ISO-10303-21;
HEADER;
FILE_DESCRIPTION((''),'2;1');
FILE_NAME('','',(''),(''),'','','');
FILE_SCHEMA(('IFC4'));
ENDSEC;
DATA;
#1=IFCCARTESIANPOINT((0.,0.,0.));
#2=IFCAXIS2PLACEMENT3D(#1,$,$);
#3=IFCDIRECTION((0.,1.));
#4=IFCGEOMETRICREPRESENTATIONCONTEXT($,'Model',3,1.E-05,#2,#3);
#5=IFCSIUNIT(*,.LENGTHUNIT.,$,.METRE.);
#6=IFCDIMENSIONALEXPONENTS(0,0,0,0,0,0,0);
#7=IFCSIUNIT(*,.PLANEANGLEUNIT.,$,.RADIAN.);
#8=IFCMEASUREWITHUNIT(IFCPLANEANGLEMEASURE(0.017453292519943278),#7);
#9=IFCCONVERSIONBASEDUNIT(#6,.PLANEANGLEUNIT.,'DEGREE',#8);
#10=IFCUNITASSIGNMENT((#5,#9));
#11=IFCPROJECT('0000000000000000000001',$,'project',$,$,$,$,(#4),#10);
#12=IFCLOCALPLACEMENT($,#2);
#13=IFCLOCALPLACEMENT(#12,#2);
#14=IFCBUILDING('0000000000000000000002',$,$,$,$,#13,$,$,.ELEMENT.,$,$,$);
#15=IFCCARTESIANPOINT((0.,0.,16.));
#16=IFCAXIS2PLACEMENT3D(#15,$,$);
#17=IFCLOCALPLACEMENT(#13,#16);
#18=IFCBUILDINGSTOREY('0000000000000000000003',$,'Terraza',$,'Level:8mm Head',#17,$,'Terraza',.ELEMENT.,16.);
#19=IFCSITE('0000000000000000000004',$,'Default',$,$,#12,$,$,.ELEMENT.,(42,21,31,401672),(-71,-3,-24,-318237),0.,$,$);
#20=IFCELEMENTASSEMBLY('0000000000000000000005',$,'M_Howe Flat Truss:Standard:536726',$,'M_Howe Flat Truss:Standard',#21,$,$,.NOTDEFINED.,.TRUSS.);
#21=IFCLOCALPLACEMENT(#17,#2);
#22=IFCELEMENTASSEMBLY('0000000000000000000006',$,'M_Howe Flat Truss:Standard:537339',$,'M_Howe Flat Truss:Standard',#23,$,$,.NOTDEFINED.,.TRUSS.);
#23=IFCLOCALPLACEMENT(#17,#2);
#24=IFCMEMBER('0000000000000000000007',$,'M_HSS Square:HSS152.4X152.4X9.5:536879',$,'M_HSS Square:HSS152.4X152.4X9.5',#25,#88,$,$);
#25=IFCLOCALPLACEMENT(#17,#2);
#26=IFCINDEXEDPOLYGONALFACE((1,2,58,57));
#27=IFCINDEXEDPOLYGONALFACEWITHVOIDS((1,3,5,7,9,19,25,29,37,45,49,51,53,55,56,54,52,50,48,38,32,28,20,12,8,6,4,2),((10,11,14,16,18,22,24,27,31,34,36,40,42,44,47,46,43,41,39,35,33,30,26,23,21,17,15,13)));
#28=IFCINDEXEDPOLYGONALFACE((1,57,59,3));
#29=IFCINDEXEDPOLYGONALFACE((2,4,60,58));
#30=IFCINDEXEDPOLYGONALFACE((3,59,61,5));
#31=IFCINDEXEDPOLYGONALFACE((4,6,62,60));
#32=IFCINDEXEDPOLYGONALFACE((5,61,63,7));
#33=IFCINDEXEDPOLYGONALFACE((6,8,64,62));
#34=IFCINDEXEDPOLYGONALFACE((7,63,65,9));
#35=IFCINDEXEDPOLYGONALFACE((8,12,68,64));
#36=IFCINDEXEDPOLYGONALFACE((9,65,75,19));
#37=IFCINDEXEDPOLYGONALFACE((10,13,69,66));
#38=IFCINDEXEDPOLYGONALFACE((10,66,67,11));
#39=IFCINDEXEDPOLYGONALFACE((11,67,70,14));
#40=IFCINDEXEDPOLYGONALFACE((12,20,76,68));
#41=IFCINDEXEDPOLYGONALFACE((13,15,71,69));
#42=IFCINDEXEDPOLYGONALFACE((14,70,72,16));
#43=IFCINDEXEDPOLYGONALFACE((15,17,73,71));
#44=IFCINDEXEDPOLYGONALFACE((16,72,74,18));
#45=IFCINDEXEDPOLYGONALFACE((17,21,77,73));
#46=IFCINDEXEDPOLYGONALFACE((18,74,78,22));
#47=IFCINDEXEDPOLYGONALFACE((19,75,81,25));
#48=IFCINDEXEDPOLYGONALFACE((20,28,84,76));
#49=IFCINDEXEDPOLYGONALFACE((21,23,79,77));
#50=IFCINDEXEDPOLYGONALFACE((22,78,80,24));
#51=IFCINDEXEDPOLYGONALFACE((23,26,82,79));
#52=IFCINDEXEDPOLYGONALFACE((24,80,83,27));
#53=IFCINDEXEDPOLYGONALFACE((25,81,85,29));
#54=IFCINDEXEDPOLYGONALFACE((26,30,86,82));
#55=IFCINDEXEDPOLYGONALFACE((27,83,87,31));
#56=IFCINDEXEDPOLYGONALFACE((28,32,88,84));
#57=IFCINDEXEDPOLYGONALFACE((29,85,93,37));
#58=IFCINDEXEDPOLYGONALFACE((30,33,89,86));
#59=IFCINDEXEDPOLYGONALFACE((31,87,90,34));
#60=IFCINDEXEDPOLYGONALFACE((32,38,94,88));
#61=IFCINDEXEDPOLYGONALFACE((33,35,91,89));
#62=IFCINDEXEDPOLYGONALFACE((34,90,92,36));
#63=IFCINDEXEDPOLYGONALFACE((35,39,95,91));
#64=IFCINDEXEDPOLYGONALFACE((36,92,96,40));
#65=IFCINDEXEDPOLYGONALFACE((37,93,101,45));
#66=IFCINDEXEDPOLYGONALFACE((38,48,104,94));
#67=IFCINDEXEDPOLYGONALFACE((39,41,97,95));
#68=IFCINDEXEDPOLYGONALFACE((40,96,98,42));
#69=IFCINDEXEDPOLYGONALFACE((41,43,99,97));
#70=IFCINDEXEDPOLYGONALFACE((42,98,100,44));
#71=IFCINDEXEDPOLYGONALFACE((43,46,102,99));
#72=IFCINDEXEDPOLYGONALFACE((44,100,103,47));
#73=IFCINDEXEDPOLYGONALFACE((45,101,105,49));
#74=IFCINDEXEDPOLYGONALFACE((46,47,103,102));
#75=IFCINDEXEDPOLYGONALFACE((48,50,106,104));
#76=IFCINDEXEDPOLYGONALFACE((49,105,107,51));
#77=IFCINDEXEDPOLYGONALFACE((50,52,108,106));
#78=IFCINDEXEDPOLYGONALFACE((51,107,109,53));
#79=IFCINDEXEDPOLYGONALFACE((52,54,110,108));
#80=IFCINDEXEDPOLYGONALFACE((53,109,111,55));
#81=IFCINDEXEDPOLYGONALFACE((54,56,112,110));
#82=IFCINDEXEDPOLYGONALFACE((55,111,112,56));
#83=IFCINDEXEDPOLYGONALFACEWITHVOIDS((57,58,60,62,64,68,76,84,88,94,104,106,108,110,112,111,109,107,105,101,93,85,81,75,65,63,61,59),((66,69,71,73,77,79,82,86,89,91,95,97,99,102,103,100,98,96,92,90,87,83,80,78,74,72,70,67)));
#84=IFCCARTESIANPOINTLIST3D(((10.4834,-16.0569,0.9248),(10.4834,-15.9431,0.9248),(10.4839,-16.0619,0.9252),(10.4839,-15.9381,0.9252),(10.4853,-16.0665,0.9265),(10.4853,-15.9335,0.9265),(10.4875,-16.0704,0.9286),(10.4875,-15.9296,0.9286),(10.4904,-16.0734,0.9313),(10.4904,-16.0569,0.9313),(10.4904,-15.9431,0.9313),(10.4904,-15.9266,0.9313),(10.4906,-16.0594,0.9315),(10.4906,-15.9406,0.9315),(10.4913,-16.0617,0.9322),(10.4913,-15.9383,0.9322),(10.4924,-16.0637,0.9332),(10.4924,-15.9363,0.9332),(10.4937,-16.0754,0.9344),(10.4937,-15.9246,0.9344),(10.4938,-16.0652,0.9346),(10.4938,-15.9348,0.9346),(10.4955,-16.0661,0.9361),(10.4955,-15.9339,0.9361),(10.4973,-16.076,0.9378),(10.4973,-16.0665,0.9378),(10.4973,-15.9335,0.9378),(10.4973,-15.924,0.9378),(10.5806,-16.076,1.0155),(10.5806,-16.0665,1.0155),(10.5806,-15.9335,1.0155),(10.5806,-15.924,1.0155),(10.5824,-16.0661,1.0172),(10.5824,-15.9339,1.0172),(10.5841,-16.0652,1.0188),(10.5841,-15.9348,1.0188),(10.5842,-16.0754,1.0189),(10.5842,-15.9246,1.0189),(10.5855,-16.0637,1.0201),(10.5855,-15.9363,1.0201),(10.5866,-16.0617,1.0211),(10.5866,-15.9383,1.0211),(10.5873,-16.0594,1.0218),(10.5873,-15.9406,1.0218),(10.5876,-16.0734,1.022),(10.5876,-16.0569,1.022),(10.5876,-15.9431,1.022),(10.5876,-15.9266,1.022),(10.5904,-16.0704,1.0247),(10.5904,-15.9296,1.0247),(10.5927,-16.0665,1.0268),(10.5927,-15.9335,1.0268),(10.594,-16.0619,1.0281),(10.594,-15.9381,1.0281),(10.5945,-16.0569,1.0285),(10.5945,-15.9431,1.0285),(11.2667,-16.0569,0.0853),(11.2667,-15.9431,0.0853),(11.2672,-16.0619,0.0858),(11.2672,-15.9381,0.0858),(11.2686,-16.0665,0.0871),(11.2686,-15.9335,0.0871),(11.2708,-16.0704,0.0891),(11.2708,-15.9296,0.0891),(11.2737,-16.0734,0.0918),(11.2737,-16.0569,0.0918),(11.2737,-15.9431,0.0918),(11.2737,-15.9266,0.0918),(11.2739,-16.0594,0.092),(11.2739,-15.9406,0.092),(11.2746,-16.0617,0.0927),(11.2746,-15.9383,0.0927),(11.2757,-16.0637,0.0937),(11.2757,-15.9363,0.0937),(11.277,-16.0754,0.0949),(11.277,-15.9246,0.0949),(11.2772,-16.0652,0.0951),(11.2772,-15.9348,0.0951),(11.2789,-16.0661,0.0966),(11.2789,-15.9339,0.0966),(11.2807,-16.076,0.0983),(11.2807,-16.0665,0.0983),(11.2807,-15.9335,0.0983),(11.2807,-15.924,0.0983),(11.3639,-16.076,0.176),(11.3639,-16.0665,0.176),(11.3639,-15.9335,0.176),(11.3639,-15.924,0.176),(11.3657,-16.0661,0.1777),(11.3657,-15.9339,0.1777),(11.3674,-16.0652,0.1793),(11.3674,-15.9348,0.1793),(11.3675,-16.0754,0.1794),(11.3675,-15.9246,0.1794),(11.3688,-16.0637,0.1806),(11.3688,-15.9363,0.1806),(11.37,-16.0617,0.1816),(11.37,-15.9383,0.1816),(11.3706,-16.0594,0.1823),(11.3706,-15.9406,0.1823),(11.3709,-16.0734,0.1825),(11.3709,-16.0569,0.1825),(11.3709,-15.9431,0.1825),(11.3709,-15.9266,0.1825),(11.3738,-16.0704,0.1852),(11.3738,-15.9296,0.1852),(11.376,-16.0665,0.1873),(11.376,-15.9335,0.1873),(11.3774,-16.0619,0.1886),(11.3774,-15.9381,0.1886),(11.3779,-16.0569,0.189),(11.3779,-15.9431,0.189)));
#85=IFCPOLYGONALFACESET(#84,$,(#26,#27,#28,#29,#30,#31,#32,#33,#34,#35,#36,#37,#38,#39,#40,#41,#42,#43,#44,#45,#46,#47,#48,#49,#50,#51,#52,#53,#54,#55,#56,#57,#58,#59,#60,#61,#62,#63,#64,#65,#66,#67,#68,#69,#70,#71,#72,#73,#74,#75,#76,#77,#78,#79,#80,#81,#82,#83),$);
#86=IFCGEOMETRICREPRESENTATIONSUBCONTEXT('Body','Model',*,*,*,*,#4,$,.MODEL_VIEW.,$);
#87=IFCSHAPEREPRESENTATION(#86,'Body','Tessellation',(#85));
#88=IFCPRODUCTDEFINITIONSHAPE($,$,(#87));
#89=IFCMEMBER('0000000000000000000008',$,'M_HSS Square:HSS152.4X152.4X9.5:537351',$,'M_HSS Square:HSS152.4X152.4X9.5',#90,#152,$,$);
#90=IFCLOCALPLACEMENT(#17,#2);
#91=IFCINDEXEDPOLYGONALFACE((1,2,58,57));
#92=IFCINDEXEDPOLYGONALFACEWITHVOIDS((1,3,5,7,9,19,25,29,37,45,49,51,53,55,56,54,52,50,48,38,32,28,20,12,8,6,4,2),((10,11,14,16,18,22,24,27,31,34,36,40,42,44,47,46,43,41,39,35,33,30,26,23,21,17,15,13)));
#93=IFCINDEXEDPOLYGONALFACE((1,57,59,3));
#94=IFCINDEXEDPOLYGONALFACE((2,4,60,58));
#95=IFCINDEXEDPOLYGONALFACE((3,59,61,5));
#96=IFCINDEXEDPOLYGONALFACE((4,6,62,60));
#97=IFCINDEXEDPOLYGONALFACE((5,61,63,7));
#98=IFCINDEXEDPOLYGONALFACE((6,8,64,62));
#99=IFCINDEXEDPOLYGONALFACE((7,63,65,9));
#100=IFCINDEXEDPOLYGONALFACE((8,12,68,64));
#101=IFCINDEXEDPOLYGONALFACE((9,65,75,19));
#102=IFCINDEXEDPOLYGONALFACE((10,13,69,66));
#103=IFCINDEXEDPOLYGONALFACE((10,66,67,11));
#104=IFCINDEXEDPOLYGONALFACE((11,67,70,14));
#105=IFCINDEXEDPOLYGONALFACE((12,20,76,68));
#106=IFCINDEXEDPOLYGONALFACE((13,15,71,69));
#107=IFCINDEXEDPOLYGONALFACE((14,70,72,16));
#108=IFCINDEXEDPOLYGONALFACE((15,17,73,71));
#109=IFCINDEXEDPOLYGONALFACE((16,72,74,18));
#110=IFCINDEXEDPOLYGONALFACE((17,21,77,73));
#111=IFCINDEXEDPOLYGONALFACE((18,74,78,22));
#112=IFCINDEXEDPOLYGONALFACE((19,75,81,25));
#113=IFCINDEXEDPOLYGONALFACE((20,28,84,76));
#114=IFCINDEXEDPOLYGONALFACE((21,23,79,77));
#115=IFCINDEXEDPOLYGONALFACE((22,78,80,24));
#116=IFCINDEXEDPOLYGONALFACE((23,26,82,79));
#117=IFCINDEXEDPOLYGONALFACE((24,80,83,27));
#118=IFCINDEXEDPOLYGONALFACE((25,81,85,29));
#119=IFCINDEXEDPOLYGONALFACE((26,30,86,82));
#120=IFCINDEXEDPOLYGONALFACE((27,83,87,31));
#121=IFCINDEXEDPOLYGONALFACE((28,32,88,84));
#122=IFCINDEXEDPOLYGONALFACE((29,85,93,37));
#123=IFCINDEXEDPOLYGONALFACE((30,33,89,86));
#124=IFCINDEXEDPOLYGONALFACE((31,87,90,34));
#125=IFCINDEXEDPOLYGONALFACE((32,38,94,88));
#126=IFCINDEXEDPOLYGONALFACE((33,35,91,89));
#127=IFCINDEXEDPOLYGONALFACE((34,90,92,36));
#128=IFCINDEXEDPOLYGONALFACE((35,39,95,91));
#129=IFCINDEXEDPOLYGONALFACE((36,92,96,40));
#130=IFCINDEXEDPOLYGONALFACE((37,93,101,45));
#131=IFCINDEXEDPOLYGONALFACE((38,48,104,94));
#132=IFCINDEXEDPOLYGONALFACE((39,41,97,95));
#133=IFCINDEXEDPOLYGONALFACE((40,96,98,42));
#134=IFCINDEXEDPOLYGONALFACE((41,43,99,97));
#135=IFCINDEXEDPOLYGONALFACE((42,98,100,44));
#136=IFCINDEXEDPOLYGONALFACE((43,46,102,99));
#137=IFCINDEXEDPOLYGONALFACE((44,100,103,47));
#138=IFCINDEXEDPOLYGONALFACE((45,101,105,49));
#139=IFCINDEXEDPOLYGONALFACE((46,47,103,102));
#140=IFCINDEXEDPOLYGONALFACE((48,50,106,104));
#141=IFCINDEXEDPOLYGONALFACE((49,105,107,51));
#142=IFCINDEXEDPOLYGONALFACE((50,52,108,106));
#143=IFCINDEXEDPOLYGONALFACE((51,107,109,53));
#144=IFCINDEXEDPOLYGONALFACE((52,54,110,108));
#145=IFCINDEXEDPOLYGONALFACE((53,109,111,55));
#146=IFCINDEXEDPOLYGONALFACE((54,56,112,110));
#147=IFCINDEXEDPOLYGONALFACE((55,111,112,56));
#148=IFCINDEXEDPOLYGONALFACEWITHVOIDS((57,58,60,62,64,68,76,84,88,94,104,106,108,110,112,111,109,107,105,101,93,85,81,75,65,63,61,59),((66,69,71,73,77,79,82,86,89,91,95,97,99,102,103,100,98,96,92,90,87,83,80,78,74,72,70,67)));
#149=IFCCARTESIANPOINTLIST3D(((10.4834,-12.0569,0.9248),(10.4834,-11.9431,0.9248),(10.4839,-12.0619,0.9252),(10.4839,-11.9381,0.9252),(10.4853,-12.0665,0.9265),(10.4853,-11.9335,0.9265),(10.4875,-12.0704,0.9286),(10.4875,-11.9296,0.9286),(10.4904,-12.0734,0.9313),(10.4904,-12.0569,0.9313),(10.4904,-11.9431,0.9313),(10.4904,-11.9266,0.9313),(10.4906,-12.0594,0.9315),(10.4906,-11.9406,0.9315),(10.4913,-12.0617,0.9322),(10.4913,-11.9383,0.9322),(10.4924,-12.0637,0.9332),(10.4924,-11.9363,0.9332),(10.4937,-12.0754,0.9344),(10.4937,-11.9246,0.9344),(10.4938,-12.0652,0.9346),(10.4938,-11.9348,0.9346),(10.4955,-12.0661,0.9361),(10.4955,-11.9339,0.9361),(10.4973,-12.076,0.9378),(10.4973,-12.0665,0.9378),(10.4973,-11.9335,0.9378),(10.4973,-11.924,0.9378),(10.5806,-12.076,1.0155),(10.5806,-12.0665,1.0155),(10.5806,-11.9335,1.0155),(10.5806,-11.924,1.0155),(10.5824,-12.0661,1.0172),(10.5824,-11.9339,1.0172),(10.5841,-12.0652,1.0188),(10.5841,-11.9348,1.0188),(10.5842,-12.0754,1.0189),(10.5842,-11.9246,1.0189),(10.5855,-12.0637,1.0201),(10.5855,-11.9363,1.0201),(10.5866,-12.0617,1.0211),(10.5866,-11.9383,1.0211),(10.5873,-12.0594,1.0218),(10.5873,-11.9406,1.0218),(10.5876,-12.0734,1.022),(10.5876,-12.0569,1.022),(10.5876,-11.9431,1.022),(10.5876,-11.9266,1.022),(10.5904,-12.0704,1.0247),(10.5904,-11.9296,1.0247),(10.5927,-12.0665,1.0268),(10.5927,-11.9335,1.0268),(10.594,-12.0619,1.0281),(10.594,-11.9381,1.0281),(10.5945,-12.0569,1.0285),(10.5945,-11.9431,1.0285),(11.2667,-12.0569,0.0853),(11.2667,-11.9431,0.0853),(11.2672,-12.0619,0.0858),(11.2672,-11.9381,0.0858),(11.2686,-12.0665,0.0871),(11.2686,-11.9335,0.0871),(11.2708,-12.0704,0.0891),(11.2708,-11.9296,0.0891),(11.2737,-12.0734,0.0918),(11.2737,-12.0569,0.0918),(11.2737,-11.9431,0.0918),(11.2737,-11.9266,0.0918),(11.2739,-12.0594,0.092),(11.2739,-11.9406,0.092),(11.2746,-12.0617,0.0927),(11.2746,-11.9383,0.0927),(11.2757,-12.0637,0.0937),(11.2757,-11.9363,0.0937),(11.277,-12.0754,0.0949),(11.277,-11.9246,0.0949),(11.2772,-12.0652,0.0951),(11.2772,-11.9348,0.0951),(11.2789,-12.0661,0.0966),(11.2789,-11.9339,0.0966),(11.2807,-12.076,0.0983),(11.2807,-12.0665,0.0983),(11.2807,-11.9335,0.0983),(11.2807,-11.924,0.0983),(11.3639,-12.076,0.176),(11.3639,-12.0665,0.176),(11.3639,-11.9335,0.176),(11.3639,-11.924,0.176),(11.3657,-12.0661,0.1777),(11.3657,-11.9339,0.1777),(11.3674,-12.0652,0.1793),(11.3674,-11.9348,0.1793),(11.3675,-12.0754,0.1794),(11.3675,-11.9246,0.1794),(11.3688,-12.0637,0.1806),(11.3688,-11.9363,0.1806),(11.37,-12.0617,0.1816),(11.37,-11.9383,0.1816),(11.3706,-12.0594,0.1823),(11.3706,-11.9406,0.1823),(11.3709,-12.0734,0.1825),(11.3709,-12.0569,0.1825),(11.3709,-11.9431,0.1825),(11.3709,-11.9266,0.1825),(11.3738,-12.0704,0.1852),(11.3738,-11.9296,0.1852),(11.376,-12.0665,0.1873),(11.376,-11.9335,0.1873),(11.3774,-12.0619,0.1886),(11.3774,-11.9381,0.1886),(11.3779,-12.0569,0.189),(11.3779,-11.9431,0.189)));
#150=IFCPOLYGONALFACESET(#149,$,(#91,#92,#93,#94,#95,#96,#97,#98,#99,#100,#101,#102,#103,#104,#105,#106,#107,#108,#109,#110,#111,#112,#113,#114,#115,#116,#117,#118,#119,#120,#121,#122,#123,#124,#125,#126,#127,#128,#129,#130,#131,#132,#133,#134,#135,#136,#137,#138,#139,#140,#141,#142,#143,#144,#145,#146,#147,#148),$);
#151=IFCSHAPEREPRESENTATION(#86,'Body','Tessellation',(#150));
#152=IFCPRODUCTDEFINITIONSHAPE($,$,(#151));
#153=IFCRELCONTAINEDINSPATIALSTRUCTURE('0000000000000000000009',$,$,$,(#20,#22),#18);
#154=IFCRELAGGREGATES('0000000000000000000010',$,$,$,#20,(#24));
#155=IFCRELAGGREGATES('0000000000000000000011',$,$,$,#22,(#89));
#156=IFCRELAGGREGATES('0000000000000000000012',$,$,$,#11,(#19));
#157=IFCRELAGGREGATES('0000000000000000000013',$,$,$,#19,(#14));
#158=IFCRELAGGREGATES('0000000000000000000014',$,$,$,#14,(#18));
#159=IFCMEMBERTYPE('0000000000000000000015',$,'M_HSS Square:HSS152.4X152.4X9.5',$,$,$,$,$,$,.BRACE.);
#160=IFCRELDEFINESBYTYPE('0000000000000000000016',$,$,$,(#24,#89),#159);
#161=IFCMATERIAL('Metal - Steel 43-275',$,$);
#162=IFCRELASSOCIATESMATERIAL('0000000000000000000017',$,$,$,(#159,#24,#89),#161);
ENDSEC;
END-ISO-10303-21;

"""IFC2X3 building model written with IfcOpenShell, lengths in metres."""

from ifc_helpers import new_model, entity, si_unit, converted_unit, direction, frame, frame_2d, origin, place, context, subcontext, project, spatial, polyline, circle_curve, parameter, trimmed, segment, composite_curve, outline, extrude, source, transform, mapped, material, type_object, type_shapes, element, aggregate, save


model = new_model("IFC2X3")

# Units and contexts
model_context = context("Model", 3, precision=1e-05, world=origin(), true_north=direction((0.0, 1.0)))
body_context = subcontext(model_context, "Body", "Model", "MODEL_VIEW")
ifc_project = project(units=[si_unit("LENGTHUNIT", "METRE"), converted_unit("PLANEANGLEUNIT", "DEGREE", entity("IfcPlaneAngleMeasure", 0.017453292519943278), si_unit("PLANEANGLEUNIT", "RADIAN"), dimensions=[0, 0, 0, 0, 0, 0, 0])], contexts=[model_context])

# Site, building, storey
site_placement = place(None, origin())
site = spatial("IfcSite", under=ifc_project, at=site_placement, Name="Default", CompositionType="ELEMENT", RefLatitude=(42, 21, 31, 401672), RefLongitude=(-71, -3, -24, -318237), RefElevation=0.0)
building_placement = place(site_placement, origin())
building = spatial("IfcBuilding", under=site, at=building_placement, CompositionType="ELEMENT")
storey_placement = place(building_placement, frame((0.0, 0.0, 16.0)))
storey = spatial("IfcBuildingStorey", under=building, at=storey_placement, Name="Terraza", ObjectType="Level:8mm Head", LongName="Terraza", CompositionType="ELEMENT", Elevation=16.0)

# Element assemblies
assembly_1_placement = place(storey_placement, origin())
assembly_1 = element("IfcElementAssembly", 1, at=assembly_1_placement, inside=storey, Name="M_Howe Flat Truss:Standard:536726", ObjectType="M_Howe Flat Truss:Standard", AssemblyPlace="NOTDEFINED", PredefinedType="TRUSS")
ifc_material = material(Name="Metal - Steel 43-275")
assembly_2_placement = place(storey_placement, origin())
assembly_2 = element("IfcElementAssembly", 2, at=assembly_2_placement, inside=storey, Name="M_Howe Flat Truss:Standard:537339", ObjectType="M_Howe Flat Truss:Standard", AssemblyPlace="NOTDEFINED", PredefinedType="TRUSS")

# Members
member_type_1 = type_object("IfcMemberType", Name="M_HSS Square:HSS152.4X152.4X9.5", PredefinedType="BRACE", material=ifc_material)
shared_shape_1 = source(origin(), body_context, "Body", "SweptSolid", [
    extrude(outline(composite_curve([segment(polyline([(-0.0569, -0.076), (0.0569, -0.076)]), True, "CONTINUOUS"), segment(trimmed(circle_curve(frame_2d((0.0569, -0.0569), x_axis=(0.0, 1.0)), 0.0191), [parameter(180.0)], [parameter(270.0)], True, "PARAMETER"), True, "CONTINUOUS"), segment(polyline([(0.076, -0.0569), (0.076, 0.0569)]), True, "CONTINUOUS"), segment(trimmed(circle_curve(frame_2d((0.0569, 0.0569), x_axis=(0.0, 1.0)), 0.0191), [parameter(270.0)], [parameter(0.0)], True, "PARAMETER"), True, "CONTINUOUS"), segment(polyline([(0.0569, 0.076), (-0.0569, 0.076)]), True, "CONTINUOUS"), segment(trimmed(circle_curve(frame_2d((-0.0569, 0.0569), x_axis=(0.0, 1.0)), 0.0191), [parameter(0.0)], [parameter(90.0)], True, "PARAMETER"), True, "CONTINUOUS"), segment(polyline([(-0.076, 0.0569), (-0.076, -0.0569)]), True, "CONTINUOUS"), segment(trimmed(circle_curve(frame_2d((-0.0569, -0.0569), x_axis=(0.0, 1.0)), 0.0191), [parameter(90.0)], [parameter(180.0)], True, "PARAMETER"), True, "CONTINUOUS")], self_intersect=False), holes=[composite_curve([segment(trimmed(circle_curve(frame_2d((-0.0569, 0.0569), x_axis=(0.0, 1.0)), 0.0095), [parameter(360.0)], [parameter(90.0)], True, "PARAMETER"), False, "CONTINUOUS"), segment(polyline([(-0.0569, 0.0665), (0.0569, 0.0665)]), True, "CONTINUOUS"), segment(trimmed(circle_curve(frame_2d((0.0569, 0.0569), x_axis=(0.0, 1.0)), 0.0095), [parameter(270.0)], [parameter(360.0)], True, "PARAMETER"), False, "CONTINUOUS"), segment(polyline([(0.0665, 0.0569), (0.0665, -0.0569)]), True, "CONTINUOUS"), segment(trimmed(circle_curve(frame_2d((0.0569, -0.0569), x_axis=(0.0, 1.0)), 0.0095), [parameter(180.0)], [parameter(270.0)], True, "PARAMETER"), False, "CONTINUOUS"), segment(polyline([(0.0569, -0.0665), (-0.0569, -0.0665)]), True, "CONTINUOUS"), segment(trimmed(circle_curve(frame_2d((-0.0569, -0.0569), x_axis=(0.0, 1.0)), 0.0095), [parameter(90.0)], [parameter(180.0)], True, "PARAMETER"), False, "CONTINUOUS"), segment(polyline([(-0.0665, -0.0569), (-0.0665, 0.0569)]), True, "CONTINUOUS")], self_intersect=False)]), frame((-0.5665, 0.0, 0.0), z_axis=(1.0, 0.0, 0.0), x_axis=(0.0, 0.0, -1.0)), (0.0, 0.0, 1.0), 1.1482),
])
type_shapes(member_type_1, [shared_shape_1])
member_1_placement = place(assembly_1_placement, frame((10.9254, -16.0, 0.5625), z_axis=(-0.731142, 0.0, -0.682225), x_axis=(0.682225, 0.0, -0.731142)))
member_1 = element("IfcMember", 3, at=member_1_placement, type_object=member_type_1, material=ifc_material, Name="M_HSS Square:HSS152.4X152.4X9.5:536879", ObjectType="M_HSS Square:HSS152.4X152.4X9.5", context=body_context, shape_type="MappedRepresentation", body=[
    mapped(shared_shape_1, transform((0.0, 0.0, 0.0), scale=1.0)),
])
member_2_placement = place(assembly_2_placement, frame((10.9254, -12.0, 0.5625), z_axis=(-0.731142, 0.0, -0.682225), x_axis=(0.682225, 0.0, -0.731142)))
member_2 = element("IfcMember", 4, at=member_2_placement, type_object=member_type_1, material=ifc_material, Name="M_HSS Square:HSS152.4X152.4X9.5:537351", ObjectType="M_HSS Square:HSS152.4X152.4X9.5", context=body_context, shape_type="MappedRepresentation", body=[
    mapped(shared_shape_1, transform((0.0, 0.0, 0.0), scale=1.0)),
])
aggregate(assembly_1, [member_1])
aggregate(assembly_2, [member_2])

save(model, "model.ifc")
